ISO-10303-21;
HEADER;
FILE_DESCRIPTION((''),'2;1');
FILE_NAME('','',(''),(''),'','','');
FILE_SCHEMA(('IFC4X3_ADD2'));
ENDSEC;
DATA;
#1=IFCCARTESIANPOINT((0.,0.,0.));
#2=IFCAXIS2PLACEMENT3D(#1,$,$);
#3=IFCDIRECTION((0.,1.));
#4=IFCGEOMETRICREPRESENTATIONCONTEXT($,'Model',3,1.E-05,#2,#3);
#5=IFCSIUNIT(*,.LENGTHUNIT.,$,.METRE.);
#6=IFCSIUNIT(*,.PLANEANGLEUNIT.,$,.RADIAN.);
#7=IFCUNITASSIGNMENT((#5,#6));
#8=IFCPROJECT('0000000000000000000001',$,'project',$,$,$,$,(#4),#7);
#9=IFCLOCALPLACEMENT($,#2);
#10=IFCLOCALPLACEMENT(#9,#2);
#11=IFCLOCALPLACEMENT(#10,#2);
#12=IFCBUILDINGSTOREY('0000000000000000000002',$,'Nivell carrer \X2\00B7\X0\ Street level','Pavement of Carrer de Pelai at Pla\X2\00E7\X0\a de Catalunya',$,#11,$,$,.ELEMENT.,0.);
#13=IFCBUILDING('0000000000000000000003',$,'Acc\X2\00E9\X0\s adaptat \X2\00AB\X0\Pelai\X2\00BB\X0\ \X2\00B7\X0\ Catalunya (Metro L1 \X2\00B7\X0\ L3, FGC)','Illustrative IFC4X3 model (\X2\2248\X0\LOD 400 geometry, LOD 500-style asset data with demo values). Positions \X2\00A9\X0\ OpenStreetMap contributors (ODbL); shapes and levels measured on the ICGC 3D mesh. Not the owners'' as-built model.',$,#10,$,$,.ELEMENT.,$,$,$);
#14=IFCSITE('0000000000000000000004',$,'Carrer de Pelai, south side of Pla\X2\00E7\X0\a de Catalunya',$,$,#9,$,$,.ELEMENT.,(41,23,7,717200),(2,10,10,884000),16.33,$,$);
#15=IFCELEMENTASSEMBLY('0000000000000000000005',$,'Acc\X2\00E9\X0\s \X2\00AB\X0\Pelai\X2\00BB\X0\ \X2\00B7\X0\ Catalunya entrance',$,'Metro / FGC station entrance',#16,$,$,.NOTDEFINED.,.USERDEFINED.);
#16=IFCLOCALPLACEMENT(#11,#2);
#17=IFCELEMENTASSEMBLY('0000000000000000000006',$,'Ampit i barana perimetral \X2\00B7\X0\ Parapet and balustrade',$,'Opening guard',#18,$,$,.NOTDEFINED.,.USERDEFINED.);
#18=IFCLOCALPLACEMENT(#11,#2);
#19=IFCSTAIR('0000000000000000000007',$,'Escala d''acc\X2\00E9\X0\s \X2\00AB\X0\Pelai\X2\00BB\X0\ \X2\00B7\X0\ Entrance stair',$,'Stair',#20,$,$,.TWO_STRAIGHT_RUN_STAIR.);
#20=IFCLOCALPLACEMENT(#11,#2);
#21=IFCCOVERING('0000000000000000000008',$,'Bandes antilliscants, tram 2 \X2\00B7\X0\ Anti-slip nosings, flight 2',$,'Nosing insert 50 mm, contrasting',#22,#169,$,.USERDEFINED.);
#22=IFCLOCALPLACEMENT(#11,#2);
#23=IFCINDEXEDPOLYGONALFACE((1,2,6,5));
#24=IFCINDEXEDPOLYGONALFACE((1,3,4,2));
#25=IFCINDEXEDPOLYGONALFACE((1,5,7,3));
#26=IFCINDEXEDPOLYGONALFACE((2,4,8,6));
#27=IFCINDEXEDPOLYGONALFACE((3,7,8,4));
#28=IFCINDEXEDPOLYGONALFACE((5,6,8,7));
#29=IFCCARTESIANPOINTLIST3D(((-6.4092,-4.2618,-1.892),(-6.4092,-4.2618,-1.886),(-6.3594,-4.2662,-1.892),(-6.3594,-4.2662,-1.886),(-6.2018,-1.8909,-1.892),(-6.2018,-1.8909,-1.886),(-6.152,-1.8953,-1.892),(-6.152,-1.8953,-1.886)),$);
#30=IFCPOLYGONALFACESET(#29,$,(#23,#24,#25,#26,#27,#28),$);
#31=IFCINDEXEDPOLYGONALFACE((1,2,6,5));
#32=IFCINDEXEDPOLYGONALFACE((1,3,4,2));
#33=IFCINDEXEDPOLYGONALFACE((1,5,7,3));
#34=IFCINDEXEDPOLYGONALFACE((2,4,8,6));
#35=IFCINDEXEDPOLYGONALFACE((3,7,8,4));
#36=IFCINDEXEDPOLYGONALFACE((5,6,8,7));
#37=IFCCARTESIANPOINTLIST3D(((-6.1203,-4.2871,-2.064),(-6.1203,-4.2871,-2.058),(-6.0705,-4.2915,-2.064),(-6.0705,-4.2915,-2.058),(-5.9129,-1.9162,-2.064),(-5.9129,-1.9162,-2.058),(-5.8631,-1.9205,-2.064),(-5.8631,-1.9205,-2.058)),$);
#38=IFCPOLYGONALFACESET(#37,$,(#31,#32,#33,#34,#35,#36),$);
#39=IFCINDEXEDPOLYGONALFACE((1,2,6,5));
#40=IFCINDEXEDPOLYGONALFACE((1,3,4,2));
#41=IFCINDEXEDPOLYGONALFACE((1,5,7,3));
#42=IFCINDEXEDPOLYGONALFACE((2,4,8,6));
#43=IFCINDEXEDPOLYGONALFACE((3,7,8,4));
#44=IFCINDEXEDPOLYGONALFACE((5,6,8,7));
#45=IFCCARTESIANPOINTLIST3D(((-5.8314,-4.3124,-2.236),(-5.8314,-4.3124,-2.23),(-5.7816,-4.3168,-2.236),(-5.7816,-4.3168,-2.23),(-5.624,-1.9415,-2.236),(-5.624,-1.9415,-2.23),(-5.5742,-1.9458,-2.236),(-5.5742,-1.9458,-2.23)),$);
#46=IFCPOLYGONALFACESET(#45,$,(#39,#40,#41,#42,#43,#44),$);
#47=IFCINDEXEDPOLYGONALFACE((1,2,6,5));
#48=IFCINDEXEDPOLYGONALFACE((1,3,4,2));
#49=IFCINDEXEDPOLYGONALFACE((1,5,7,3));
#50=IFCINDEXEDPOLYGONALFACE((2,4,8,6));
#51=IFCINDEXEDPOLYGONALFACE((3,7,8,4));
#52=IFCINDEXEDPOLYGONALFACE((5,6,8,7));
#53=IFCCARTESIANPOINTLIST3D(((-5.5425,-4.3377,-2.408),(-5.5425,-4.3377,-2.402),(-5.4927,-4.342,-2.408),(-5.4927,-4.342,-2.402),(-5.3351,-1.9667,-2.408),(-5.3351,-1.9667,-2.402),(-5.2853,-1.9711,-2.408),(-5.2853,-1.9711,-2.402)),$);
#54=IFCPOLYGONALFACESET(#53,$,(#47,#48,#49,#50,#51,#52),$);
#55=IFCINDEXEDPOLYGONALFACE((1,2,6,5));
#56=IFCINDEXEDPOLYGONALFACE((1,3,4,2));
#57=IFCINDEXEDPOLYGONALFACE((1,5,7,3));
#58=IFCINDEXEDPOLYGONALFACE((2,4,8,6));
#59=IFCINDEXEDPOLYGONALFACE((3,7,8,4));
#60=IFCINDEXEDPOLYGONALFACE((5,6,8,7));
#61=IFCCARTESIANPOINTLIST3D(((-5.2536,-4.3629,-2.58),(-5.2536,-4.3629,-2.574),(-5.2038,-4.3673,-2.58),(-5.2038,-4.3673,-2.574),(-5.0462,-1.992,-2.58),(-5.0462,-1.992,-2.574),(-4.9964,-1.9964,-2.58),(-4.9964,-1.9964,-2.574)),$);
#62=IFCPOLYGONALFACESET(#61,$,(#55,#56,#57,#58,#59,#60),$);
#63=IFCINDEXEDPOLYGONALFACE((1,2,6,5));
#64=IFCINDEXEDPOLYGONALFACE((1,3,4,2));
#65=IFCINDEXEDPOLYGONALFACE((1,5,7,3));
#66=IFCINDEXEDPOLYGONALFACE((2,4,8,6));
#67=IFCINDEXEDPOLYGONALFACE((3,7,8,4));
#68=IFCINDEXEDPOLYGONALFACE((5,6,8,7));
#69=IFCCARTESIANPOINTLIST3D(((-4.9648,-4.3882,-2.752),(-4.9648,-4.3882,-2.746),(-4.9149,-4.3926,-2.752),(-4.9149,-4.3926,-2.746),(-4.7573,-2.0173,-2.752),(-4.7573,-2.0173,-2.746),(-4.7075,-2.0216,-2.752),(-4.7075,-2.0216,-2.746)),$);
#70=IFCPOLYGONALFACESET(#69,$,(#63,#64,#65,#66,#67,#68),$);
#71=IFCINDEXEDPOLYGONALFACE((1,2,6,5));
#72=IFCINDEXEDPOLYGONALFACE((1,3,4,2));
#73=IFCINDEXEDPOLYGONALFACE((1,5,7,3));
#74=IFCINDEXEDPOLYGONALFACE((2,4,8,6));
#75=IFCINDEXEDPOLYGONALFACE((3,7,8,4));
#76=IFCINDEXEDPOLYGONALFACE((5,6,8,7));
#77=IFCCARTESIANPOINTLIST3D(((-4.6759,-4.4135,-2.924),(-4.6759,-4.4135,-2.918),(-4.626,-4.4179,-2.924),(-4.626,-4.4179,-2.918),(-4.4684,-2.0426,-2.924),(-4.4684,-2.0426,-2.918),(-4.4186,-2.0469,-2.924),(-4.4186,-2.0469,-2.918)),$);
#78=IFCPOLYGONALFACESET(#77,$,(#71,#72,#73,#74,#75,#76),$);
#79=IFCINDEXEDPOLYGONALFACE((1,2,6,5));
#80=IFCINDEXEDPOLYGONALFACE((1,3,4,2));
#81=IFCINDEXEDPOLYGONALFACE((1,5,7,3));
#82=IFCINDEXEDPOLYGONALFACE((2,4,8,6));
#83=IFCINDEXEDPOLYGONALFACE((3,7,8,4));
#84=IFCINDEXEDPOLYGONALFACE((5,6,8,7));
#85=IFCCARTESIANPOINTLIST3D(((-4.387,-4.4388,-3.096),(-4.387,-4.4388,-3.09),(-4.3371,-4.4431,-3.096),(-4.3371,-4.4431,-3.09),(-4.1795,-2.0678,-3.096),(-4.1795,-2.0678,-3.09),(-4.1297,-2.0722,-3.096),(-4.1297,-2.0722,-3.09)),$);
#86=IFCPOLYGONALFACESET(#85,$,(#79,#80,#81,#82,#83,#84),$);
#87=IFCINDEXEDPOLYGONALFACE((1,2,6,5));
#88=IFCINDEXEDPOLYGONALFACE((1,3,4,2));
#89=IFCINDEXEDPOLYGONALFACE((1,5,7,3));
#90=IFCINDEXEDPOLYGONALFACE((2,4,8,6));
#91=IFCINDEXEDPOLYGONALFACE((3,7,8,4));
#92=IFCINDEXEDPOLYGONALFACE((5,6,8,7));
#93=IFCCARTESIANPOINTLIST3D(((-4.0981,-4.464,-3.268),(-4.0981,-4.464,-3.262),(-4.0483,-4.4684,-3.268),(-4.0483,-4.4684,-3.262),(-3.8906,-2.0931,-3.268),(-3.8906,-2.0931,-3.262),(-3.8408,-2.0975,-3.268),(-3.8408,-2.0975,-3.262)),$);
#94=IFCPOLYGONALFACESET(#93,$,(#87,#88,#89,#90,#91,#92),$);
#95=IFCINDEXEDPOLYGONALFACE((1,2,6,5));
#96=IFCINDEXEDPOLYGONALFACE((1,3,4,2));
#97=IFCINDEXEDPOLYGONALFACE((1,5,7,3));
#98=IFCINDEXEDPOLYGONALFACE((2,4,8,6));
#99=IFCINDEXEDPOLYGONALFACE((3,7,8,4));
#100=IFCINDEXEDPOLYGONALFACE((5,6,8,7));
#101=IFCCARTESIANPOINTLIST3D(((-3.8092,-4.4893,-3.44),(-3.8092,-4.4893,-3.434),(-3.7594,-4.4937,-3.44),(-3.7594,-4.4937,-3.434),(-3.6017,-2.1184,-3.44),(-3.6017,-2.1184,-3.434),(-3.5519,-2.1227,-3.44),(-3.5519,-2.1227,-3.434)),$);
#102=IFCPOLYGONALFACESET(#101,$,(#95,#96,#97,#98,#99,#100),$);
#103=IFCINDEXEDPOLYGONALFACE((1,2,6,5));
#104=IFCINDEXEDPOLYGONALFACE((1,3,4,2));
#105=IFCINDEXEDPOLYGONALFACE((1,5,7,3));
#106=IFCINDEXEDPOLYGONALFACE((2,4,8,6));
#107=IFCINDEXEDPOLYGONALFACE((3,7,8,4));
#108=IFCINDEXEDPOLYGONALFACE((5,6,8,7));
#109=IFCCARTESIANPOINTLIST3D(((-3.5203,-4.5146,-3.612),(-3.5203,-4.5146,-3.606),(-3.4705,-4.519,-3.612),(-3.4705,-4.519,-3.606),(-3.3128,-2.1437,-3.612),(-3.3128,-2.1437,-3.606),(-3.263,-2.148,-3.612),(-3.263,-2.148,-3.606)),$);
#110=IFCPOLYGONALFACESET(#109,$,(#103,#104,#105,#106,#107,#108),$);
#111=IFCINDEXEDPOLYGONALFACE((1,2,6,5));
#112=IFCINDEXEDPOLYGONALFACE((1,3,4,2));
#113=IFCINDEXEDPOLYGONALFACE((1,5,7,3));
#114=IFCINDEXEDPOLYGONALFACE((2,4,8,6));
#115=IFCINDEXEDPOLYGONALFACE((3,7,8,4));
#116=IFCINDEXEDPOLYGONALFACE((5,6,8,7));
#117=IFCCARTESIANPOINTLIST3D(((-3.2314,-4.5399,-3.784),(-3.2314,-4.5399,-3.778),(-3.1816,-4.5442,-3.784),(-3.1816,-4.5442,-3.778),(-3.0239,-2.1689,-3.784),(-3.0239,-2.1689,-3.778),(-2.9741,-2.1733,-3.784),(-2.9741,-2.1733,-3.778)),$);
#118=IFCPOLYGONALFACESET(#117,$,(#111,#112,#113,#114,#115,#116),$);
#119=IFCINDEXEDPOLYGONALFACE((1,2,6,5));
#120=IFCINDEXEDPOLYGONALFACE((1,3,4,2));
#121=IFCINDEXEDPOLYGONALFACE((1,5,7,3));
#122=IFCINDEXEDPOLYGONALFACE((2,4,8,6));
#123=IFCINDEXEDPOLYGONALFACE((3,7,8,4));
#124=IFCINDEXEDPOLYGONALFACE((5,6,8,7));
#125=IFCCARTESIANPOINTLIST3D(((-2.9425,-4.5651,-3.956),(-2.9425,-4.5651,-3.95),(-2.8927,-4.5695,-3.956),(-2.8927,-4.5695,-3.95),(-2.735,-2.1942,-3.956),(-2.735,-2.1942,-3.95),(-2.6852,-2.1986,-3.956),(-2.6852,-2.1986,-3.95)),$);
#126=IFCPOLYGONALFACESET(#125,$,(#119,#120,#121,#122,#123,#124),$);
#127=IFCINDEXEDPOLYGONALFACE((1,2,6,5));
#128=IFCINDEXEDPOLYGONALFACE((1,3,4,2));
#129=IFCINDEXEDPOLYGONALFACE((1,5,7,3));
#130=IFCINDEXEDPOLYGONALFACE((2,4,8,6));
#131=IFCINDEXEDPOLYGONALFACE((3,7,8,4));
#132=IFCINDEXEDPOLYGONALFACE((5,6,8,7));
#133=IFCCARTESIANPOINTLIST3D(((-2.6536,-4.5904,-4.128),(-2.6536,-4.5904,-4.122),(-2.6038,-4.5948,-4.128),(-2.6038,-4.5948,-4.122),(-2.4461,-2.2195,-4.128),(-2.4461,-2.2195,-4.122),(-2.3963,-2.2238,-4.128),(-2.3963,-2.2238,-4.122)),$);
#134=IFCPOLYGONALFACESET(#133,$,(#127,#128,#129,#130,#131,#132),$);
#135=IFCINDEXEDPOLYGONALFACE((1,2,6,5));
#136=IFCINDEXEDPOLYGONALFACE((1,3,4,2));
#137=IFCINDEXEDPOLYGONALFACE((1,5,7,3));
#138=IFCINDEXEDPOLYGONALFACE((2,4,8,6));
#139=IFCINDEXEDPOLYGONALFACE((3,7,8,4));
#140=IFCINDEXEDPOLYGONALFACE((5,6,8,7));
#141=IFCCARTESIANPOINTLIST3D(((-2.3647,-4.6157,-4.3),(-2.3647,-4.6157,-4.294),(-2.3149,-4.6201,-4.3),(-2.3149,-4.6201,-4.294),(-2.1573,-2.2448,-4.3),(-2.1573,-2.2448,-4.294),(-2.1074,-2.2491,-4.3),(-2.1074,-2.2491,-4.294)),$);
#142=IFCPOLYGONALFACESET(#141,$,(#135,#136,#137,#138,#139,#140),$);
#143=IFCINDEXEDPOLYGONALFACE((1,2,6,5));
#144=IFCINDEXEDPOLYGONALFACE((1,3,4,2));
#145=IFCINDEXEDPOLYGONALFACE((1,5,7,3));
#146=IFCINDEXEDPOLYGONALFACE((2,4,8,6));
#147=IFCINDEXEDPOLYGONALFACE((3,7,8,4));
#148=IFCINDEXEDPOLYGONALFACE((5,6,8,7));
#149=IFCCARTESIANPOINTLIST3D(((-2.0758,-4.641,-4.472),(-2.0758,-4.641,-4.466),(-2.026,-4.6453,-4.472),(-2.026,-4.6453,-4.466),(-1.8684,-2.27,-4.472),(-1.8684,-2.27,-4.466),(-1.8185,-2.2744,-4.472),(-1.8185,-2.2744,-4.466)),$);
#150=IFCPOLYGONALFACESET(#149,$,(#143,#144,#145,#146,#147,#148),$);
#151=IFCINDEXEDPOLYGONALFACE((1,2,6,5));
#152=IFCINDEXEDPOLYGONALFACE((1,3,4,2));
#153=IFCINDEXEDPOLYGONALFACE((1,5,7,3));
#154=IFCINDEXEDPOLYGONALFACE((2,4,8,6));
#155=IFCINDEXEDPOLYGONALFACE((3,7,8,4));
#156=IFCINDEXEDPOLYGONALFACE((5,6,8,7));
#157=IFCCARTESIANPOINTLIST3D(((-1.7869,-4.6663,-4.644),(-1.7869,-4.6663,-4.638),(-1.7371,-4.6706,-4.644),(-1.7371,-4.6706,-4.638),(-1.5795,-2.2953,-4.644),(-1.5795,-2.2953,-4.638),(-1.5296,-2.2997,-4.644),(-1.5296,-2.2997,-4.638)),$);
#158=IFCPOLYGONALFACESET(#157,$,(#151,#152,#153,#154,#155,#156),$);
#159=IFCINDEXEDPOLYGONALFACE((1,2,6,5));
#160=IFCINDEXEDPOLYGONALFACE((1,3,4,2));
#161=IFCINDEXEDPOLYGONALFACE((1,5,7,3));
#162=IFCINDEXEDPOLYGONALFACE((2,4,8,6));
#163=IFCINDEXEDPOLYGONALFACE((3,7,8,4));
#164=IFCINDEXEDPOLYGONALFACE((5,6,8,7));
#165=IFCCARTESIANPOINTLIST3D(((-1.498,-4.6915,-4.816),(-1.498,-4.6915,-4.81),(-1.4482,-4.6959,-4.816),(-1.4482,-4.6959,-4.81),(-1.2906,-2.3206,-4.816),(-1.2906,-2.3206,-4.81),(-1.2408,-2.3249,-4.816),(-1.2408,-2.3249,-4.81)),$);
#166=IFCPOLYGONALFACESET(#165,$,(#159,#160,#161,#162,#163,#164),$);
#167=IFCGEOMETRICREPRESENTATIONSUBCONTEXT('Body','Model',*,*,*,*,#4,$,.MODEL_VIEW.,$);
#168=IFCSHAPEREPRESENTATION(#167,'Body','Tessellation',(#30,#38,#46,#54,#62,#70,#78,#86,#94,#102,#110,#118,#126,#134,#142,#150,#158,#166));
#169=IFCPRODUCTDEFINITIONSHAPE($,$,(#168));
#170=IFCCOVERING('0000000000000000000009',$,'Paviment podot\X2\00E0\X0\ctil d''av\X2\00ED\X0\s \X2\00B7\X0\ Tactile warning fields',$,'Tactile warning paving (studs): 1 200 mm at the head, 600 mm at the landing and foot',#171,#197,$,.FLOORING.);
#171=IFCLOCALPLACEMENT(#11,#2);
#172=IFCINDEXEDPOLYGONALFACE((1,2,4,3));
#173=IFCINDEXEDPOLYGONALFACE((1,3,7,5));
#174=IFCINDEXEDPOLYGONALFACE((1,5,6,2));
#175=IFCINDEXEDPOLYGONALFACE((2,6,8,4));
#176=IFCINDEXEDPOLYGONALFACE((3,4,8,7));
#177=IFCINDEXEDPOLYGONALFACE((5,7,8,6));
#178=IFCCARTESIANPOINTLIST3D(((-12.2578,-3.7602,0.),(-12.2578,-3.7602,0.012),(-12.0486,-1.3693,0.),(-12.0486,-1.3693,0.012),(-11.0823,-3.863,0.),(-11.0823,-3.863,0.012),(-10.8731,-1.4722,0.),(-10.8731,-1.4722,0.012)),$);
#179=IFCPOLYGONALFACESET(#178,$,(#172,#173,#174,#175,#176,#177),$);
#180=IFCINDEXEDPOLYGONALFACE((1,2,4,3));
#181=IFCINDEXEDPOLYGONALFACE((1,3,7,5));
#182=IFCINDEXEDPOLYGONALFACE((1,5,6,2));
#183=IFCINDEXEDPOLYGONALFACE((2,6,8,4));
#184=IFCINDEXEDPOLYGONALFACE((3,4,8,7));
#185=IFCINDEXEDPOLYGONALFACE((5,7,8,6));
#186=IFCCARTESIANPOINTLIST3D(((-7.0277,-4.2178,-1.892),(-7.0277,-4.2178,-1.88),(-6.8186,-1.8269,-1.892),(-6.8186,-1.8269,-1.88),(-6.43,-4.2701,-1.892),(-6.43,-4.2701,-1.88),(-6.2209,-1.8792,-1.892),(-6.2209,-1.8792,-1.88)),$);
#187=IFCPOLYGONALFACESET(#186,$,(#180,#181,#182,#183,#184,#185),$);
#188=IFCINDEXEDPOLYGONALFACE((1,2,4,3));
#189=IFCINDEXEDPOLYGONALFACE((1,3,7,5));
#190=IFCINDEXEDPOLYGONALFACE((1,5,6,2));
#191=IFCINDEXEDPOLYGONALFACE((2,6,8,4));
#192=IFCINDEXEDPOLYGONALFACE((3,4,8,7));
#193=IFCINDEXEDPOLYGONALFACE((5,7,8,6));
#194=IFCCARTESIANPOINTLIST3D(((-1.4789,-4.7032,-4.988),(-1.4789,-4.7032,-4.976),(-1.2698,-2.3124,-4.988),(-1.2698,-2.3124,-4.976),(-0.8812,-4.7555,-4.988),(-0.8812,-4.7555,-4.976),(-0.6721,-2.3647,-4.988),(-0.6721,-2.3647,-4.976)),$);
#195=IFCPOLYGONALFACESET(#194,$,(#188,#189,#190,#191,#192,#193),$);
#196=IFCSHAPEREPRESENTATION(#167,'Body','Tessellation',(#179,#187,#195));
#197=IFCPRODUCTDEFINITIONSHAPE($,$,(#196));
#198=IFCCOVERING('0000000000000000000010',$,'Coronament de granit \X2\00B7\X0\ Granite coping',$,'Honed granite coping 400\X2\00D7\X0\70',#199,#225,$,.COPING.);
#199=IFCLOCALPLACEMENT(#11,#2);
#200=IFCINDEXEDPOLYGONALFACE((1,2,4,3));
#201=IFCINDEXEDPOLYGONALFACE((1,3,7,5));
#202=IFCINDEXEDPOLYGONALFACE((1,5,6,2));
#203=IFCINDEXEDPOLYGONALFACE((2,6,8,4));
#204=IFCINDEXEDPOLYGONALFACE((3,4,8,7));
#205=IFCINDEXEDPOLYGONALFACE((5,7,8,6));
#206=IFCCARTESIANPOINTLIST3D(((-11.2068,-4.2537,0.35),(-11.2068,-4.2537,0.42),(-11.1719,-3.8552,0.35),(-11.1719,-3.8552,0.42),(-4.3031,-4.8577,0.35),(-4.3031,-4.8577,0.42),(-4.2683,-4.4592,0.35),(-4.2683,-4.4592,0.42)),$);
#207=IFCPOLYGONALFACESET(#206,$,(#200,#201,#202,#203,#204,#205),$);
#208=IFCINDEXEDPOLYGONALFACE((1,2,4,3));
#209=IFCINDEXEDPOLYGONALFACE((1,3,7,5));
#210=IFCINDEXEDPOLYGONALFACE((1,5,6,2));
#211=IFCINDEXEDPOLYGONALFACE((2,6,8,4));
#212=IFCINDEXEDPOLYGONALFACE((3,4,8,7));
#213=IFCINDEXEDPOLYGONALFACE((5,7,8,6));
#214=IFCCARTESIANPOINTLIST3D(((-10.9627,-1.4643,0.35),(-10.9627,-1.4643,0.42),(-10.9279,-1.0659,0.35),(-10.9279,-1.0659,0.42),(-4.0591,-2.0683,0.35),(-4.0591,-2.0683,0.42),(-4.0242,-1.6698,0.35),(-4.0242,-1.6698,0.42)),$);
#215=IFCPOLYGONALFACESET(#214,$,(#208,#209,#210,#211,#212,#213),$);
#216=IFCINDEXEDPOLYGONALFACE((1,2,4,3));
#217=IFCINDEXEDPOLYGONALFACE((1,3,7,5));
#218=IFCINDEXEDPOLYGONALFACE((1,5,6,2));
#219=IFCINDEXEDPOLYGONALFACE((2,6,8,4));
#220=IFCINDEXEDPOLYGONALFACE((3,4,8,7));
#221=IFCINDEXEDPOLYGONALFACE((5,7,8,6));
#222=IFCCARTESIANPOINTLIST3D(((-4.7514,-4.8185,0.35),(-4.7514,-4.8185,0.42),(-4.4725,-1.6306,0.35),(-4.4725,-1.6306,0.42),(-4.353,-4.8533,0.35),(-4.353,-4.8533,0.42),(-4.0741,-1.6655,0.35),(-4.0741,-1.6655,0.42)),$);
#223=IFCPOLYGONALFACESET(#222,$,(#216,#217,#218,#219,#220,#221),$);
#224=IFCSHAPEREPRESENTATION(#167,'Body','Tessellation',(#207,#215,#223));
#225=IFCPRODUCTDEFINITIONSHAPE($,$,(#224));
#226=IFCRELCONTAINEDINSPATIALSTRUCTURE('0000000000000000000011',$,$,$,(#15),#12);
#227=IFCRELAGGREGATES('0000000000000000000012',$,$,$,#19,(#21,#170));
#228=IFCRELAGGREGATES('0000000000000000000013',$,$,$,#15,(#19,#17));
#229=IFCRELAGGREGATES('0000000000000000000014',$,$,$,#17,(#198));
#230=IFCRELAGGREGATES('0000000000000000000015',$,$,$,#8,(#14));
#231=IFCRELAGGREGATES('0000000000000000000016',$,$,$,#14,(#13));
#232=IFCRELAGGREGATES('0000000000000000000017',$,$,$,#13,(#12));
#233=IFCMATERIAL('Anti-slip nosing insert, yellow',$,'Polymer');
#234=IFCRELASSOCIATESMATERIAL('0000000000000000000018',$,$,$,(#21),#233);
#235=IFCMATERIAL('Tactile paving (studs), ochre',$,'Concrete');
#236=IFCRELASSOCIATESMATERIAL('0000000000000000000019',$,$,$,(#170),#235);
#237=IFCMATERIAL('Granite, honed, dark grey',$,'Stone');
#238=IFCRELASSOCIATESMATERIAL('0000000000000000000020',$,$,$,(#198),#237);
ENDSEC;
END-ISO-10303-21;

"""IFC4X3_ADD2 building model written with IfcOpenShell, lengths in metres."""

from ifc_helpers import new_model, si_unit, direction, frame, frame_2d, origin, place, context, subcontext, project, spatial, rectangle, extrude, material, element, aggregate, save


model = new_model("IFC4X3_ADD2")

# Units and contexts
model_context = context("Model", 3, precision=1e-05, world=origin(), true_north=direction((0.0, 1.0)))
body_context = subcontext(model_context, "Body", "Model", "MODEL_VIEW")
ifc_project = project(units=[si_unit("LENGTHUNIT", "METRE"), si_unit("PLANEANGLEUNIT", "RADIAN")], contexts=[model_context])

# Site, building, storey
site_placement = place(None, origin())
site = spatial("IfcSite", under=ifc_project, at=site_placement, Name="Carrer de Pelai, south side of Plaça de Catalunya", CompositionType="ELEMENT", RefLatitude=(41, 23, 7, 717200), RefLongitude=(2, 10, 10, 884000), RefElevation=16.33)
building_placement = place(site_placement, origin())
building = spatial("IfcBuilding", under=site, at=building_placement, Name="Accés adaptat «Pelai» · Catalunya (Metro L1 · L3, FGC)", Description="Illustrative IFC4X3 model (≈LOD 400 geometry, LOD 500-style asset data with demo values). Positions © OpenStreetMap contributors (ODbL); shapes and levels measured on the ICGC 3D mesh. Not the owners' as-built model.", CompositionType="ELEMENT")
storey_placement = place(building_placement, origin())
storey = spatial("IfcBuildingStorey", under=building, at=storey_placement, Name="Nivell carrer · Street level", Description="Pavement of Carrer de Pelai at Plaça de Catalunya", CompositionType="ELEMENT", Elevation=0.0)

# Element assemblies
assembly_1_placement = place(building_placement, origin())
assembly_1 = element("IfcElementAssembly", 1, at=assembly_1_placement, inside=storey, Name="Accés «Pelai» · Catalunya entrance", ObjectType="Metro / FGC station entrance", AssemblyPlace="NOTDEFINED", PredefinedType="USERDEFINED")
assembly_2_placement = place(building_placement, origin())
assembly_2 = element("IfcElementAssembly", 2, at=assembly_2_placement, Name="Ampit i barana perimetral · Parapet and balustrade", ObjectType="Opening guard", AssemblyPlace="NOTDEFINED", PredefinedType="USERDEFINED")

# Stair
stair_placement = place(building_placement, origin())
stair = element("IfcStair", 3, at=stair_placement, Name="Escala d'accés «Pelai» · Entrance stair", ObjectType="Stair", PredefinedType="TWO_STRAIGHT_RUN_STAIR")

# Shared definitions
ifc_material_1 = material(Name="Granite, honed, dark grey", Category="Stone")

# Coverings
ifc_material_2 = material(Name="Anti-slip nosing insert, yellow", Category="Polymer")
covering_1_placement = place(building_placement, origin())
covering_1 = element("IfcCovering", 4, at=covering_1_placement, material=ifc_material_2, Name="Bandes antilliscants, tram 2 · Anti-slip nosings, flight 2", ObjectType="Nosing insert 50 mm, contrasting", PredefinedType="USERDEFINED", context=body_context, shape_type="SweptSolid", body=[
    extrude(rectangle(XDim=0.05, YDim=2.38, at=frame_2d((0.0, 0.0), x_axis=(0.996195, -0.087156))), frame((-6.2806, -3.0786, -1.892)), (0.0, 0.0, 1.0), 0.006),
    extrude(rectangle(XDim=0.05, YDim=2.38, at=frame_2d((0.0, 0.0), x_axis=(0.996195, -0.087156))), frame((-5.9917, -3.1038, -2.064)), (0.0, 0.0, 1.0), 0.006),
    extrude(rectangle(XDim=0.05, YDim=2.38, at=frame_2d((0.0, 0.0), x_axis=(0.996195, -0.087156))), frame((-5.7028, -3.1291, -2.236)), (0.0, 0.0, 1.0), 0.006),
    extrude(rectangle(XDim=0.05, YDim=2.38, at=frame_2d((0.0, 0.0), x_axis=(0.996195, -0.087156))), frame((-5.4139, -3.1544, -2.408)), (0.0, 0.0, 1.0), 0.006),
    extrude(rectangle(XDim=0.05, YDim=2.38, at=frame_2d((0.0, 0.0), x_axis=(0.996195, -0.087156))), frame((-5.125, -3.1797, -2.58)), (0.0, 0.0, 1.0), 0.006),
    extrude(rectangle(XDim=0.05, YDim=2.38, at=frame_2d((0.0, 0.0), x_axis=(0.996195, -0.087156))), frame((-4.8361, -3.2049, -2.752)), (0.0, 0.0, 1.0), 0.006),
    extrude(rectangle(XDim=0.05, YDim=2.38, at=frame_2d((0.0, 0.0), x_axis=(0.996195, -0.087156))), frame((-4.5472, -3.2302, -2.924)), (0.0, 0.0, 1.0), 0.006),
    extrude(rectangle(XDim=0.05, YDim=2.38, at=frame_2d((0.0, 0.0), x_axis=(0.996195, -0.087156))), frame((-4.2583, -3.2555, -3.096)), (0.0, 0.0, 1.0), 0.006),
    extrude(rectangle(XDim=0.05, YDim=2.38, at=frame_2d((0.0, 0.0), x_axis=(0.996195, -0.087156))), frame((-3.9694, -3.2808, -3.268)), (0.0, 0.0, 1.0), 0.006),
    extrude(rectangle(XDim=0.05, YDim=2.38, at=frame_2d((0.0, 0.0), x_axis=(0.996195, -0.087156))), frame((-3.6805, -3.306, -3.44)), (0.0, 0.0, 1.0), 0.006),
    extrude(rectangle(XDim=0.05, YDim=2.38, at=frame_2d((0.0, 0.0), x_axis=(0.996195, -0.087156))), frame((-3.3916, -3.3313, -3.612)), (0.0, 0.0, 1.0), 0.006),
    extrude(rectangle(XDim=0.05, YDim=2.38, at=frame_2d((0.0, 0.0), x_axis=(0.996195, -0.087156))), frame((-3.1028, -3.3566, -3.784)), (0.0, 0.0, 1.0), 0.006),
    extrude(rectangle(XDim=0.05, YDim=2.38, at=frame_2d((0.0, 0.0), x_axis=(0.996195, -0.087156))), frame((-2.8139, -3.3819, -3.956)), (0.0, 0.0, 1.0), 0.006),
    extrude(rectangle(XDim=0.05, YDim=2.38, at=frame_2d((0.0, 0.0), x_axis=(0.996195, -0.087156))), frame((-2.525, -3.4071, -4.128)), (0.0, 0.0, 1.0), 0.006),
    extrude(rectangle(XDim=0.05, YDim=2.38, at=frame_2d((0.0, 0.0), x_axis=(0.996195, -0.087156))), frame((-2.2361, -3.4324, -4.3)), (0.0, 0.0, 1.0), 0.006),
    extrude(rectangle(XDim=0.05, YDim=2.38, at=frame_2d((0.0, 0.0), x_axis=(0.996195, -0.087156))), frame((-1.9472, -3.4577, -4.472)), (0.0, 0.0, 1.0), 0.006),
    extrude(rectangle(XDim=0.05, YDim=2.38, at=frame_2d((0.0, 0.0), x_axis=(0.996195, -0.087156))), frame((-1.6583, -3.483, -4.644)), (0.0, 0.0, 1.0), 0.006),
    extrude(rectangle(XDim=0.05, YDim=2.38, at=frame_2d((0.0, 0.0), x_axis=(0.996195, -0.087156))), frame((-1.3694, -3.5082, -4.816)), (0.0, 0.0, 1.0), 0.006),
])
ifc_material_3 = material(Name="Tactile paving (studs), ochre", Category="Concrete")
covering_2_placement = place(building_placement, origin())
covering_2 = element("IfcCovering", 5, at=covering_2_placement, material=ifc_material_3, Name="Paviment podotàctil d'avís · Tactile warning fields", ObjectType="Tactile warning paving (studs): 1 200 mm at the head, 600 mm at the landing and foot", PredefinedType="FLOORING", context=body_context, shape_type="SweptSolid", body=[
    extrude(rectangle(XDim=1.18, YDim=2.4, at=frame_2d((0.0, 0.0), x_axis=(0.996195, -0.087156))), frame((-11.5654, -2.6162, 0.0)), (0.0, 0.0, 1.0), 0.012),
    extrude(rectangle(XDim=0.6, YDim=2.4, at=frame_2d((0.0, 0.0), x_axis=(0.996195, -0.087156))), frame((-6.6243, -3.0485, -1.892)), (0.0, 0.0, 1.0), 0.012),
    extrude(rectangle(XDim=0.6, YDim=2.4, at=frame_2d((0.0, 0.0), x_axis=(0.996195, -0.087156))), frame((-1.0755, -3.5339, -4.988)), (0.0, 0.0, 1.0), 0.012),
])

# Covering
covering_3_placement = place(building_placement, origin())
covering_3 = element("IfcCovering", 6, at=covering_3_placement, material=ifc_material_1, Name="Coronament de granit · Granite coping", ObjectType="Honed granite coping 400×70", PredefinedType="COPING", context=body_context, shape_type="SweptSolid", body=[
    extrude(rectangle(XDim=6.93, YDim=0.4, at=frame_2d((0.0, 0.0), x_axis=(0.996195, -0.087156))), frame((-7.7375, -4.3564, 0.35)), (0.0, 0.0, 1.0), 0.07),
    extrude(rectangle(XDim=6.93, YDim=0.4, at=frame_2d((0.0, 0.0), x_axis=(0.996195, -0.087156))), frame((-7.4935, -1.5671, 0.35)), (0.0, 0.0, 1.0), 0.07),
    extrude(rectangle(XDim=0.4, YDim=3.2, at=frame_2d((0.0, 0.0), x_axis=(0.996195, -0.087156))), frame((-4.4127, -3.242, 0.35)), (0.0, 0.0, 1.0), 0.07),
])

aggregate(stair, [covering_1, covering_2])

aggregate(assembly_1, [stair, assembly_2])

aggregate(assembly_2, [covering_3])

save(model, "model.ifc")
